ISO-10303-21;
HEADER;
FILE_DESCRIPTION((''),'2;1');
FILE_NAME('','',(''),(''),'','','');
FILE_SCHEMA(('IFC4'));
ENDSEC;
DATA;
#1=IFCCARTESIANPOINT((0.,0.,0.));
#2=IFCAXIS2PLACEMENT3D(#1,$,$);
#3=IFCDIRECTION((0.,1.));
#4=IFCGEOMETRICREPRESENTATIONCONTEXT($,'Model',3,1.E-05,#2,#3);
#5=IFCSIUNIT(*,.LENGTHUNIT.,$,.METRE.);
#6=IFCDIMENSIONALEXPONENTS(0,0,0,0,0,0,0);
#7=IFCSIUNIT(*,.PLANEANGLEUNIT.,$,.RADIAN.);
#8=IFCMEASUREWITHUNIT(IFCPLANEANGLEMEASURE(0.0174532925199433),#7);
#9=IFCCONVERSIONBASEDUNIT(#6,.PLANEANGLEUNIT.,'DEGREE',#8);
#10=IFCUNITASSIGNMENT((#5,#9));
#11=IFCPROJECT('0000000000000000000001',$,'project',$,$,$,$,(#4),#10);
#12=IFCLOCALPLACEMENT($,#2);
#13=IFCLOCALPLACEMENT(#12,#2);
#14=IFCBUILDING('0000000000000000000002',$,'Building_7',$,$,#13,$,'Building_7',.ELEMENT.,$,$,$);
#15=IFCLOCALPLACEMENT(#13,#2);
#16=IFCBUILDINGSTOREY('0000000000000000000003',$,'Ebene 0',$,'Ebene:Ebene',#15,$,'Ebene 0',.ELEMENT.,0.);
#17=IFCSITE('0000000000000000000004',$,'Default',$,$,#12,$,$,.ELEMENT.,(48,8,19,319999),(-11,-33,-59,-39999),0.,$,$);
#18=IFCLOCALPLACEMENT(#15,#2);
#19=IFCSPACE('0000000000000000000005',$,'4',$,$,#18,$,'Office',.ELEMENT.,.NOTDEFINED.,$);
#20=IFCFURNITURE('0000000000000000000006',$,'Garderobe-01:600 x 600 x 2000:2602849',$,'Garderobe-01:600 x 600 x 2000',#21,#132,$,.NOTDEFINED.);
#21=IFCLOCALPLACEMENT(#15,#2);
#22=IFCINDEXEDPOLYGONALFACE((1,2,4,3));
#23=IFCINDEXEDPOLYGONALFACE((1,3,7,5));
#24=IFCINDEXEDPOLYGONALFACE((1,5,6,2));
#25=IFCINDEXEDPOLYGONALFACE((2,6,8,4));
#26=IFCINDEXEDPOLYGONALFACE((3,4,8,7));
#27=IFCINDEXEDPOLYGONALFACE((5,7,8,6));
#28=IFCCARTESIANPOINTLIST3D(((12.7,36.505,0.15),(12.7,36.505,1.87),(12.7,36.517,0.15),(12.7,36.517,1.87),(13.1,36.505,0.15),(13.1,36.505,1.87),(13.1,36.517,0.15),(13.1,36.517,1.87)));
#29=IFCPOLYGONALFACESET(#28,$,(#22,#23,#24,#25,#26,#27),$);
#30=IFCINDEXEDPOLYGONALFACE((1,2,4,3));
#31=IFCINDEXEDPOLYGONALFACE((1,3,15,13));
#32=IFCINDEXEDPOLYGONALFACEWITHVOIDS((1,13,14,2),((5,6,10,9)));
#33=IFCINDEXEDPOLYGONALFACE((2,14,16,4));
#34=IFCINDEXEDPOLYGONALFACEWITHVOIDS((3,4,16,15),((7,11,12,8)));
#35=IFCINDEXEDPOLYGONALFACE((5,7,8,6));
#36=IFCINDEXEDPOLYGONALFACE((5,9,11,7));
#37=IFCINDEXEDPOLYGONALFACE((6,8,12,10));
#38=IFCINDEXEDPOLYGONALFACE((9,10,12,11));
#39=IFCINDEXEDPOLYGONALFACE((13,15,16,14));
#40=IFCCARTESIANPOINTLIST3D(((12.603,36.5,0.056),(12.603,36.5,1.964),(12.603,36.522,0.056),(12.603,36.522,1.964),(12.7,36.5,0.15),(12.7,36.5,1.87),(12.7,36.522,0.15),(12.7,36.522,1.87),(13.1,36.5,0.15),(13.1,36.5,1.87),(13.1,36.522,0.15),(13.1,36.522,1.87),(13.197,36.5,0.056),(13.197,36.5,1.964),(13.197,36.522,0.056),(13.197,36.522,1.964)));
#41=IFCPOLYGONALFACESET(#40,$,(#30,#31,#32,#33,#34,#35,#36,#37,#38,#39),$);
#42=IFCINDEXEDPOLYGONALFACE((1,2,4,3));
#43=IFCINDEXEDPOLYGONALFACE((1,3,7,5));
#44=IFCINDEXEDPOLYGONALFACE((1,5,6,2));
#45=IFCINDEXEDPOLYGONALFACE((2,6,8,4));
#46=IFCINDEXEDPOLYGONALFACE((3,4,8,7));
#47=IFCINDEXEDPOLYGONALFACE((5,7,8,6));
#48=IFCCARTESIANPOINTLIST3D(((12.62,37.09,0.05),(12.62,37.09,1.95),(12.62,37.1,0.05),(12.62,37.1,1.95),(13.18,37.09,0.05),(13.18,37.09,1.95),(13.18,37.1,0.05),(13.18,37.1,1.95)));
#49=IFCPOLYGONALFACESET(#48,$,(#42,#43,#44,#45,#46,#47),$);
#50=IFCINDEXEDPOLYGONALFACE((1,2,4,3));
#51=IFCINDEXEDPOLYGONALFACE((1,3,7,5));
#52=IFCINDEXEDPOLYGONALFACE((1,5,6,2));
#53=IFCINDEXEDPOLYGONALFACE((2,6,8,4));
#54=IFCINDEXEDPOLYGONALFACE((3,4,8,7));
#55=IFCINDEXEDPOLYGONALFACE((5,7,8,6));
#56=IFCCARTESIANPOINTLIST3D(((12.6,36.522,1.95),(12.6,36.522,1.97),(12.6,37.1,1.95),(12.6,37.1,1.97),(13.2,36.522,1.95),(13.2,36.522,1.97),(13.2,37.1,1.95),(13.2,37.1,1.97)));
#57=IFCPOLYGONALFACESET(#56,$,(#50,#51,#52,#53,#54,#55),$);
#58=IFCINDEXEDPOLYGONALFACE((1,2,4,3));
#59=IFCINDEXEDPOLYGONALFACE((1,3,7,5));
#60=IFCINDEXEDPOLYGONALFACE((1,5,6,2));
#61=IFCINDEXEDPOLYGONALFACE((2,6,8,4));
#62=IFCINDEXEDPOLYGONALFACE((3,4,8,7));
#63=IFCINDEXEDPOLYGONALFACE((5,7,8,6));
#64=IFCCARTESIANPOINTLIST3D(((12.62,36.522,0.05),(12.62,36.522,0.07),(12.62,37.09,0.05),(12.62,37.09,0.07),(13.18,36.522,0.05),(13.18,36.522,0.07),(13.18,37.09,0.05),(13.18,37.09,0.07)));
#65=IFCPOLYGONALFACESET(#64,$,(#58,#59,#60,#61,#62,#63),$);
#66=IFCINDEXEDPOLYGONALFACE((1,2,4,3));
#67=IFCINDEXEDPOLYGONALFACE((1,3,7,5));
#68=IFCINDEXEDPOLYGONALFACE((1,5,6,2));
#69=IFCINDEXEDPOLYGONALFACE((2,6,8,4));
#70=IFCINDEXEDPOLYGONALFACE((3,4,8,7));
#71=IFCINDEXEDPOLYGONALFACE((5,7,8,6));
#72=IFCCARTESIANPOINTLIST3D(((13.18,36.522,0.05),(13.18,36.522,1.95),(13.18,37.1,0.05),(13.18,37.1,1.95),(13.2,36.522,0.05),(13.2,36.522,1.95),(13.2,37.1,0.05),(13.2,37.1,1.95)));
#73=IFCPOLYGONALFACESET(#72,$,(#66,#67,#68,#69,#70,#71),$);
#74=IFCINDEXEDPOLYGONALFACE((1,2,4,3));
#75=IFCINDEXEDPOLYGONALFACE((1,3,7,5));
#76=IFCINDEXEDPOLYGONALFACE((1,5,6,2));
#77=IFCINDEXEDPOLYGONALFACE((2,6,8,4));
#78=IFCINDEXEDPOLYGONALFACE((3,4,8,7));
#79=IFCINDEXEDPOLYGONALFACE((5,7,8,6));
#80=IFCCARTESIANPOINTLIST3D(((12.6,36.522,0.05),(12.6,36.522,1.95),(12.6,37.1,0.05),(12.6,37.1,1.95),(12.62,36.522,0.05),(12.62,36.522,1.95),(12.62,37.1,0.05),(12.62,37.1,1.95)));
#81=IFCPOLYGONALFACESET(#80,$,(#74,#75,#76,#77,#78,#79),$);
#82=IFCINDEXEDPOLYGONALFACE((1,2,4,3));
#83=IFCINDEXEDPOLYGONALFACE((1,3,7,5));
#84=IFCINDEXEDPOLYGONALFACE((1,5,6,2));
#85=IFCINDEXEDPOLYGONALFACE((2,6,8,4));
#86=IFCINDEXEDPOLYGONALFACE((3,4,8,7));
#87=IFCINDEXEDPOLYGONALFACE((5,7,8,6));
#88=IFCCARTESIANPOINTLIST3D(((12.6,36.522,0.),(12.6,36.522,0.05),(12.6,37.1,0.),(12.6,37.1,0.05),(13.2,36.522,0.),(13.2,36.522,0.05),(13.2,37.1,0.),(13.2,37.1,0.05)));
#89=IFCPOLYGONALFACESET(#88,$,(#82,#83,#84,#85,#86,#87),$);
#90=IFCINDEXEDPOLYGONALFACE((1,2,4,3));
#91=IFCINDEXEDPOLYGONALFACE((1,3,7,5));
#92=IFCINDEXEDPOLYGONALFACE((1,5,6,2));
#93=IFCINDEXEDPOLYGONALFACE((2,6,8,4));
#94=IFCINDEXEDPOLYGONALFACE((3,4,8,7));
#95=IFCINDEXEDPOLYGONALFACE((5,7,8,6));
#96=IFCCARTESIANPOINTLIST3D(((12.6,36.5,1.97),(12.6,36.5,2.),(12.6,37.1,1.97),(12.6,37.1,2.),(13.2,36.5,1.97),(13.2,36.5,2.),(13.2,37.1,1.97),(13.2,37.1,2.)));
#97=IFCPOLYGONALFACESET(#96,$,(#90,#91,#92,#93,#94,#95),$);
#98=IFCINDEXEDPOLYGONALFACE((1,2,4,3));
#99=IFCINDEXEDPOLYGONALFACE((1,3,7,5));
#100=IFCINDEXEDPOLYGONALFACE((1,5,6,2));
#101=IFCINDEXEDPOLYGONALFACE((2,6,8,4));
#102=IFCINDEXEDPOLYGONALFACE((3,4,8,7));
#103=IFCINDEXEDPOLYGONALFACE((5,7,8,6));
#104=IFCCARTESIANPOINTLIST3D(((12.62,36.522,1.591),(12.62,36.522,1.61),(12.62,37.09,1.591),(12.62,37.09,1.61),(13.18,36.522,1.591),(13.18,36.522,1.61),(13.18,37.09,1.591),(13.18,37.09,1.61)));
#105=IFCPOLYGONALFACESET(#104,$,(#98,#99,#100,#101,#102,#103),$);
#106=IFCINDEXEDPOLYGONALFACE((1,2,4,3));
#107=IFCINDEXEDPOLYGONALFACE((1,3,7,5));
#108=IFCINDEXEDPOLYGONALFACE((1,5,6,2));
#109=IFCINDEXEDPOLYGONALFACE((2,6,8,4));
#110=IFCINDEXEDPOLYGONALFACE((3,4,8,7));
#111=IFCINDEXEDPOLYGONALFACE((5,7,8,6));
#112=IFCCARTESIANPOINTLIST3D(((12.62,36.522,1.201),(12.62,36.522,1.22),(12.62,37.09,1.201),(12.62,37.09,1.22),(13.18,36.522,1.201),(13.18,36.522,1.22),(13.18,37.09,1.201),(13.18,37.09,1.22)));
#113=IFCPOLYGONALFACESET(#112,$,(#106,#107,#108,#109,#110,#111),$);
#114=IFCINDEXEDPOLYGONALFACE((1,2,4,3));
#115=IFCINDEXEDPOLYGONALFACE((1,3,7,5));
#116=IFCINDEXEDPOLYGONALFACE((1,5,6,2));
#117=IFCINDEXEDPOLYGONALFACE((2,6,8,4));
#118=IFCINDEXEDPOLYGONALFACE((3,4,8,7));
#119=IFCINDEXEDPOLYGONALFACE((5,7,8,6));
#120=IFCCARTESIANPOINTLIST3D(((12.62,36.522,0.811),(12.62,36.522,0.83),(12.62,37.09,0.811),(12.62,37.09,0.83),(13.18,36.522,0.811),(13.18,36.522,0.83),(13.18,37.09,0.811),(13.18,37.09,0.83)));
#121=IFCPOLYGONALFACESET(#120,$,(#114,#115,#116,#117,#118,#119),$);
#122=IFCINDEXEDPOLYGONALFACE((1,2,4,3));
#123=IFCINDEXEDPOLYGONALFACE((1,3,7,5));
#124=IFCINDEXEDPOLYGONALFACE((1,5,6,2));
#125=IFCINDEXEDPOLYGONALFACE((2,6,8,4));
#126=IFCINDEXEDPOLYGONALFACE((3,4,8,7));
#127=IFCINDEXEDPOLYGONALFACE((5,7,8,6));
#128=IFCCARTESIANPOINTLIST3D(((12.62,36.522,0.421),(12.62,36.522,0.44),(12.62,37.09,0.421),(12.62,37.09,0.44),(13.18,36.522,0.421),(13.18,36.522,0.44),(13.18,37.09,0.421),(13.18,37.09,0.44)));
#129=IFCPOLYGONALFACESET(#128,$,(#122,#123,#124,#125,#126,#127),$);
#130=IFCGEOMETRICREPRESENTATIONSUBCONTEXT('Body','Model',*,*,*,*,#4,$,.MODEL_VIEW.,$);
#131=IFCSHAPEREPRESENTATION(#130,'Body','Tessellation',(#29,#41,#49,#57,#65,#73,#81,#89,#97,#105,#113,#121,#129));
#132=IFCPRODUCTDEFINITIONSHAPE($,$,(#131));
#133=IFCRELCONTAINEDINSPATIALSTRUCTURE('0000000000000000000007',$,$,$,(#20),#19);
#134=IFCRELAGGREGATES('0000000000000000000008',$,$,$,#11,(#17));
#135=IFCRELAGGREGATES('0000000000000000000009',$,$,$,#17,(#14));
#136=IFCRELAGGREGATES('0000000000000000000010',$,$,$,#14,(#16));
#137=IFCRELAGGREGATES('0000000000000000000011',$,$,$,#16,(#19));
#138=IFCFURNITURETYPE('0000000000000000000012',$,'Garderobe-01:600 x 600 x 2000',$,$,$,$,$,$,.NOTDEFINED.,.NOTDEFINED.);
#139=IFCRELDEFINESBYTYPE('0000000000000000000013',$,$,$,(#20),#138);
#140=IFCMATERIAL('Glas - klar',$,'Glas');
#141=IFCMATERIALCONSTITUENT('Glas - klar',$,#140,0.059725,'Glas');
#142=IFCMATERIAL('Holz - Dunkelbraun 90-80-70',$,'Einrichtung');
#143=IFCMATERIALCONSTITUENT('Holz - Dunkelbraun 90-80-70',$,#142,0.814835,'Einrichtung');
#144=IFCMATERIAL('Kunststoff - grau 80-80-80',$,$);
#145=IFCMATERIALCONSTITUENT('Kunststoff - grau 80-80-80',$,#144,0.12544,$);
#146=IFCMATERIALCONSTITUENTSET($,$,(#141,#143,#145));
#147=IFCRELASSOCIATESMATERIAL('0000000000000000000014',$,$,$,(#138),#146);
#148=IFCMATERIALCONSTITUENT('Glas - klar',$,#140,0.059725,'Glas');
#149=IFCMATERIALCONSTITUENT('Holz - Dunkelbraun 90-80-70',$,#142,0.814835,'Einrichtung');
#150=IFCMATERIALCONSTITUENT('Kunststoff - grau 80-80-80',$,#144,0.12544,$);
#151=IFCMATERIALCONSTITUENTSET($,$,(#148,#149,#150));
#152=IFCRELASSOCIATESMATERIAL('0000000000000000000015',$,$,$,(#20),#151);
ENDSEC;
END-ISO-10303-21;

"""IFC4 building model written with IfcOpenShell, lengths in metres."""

from ifc_helpers import new_model, entity, si_unit, converted_unit, direction, frame, origin, place, context, subcontext, project, spatial, indexed_curve, outline, extrude, source, transform, mapped, material, constituent, constituent_set, type_object, type_shapes, element, save


model = new_model("IFC4")

# Units and contexts
model_context = context("Model", 3, precision=1e-05, world=origin(), true_north=direction((0.0, 1.0)))
body_context = subcontext(model_context, "Body", "Model", "MODEL_VIEW")
ifc_project = project(units=[si_unit("LENGTHUNIT", "METRE"), converted_unit("PLANEANGLEUNIT", "DEGREE", entity("IfcPlaneAngleMeasure", 0.0174532925199433), si_unit("PLANEANGLEUNIT", "RADIAN"), dimensions=[0, 0, 0, 0, 0, 0, 0])], contexts=[model_context])

# Site, building, storey
site_placement = place(None, origin())
site = spatial("IfcSite", under=ifc_project, at=site_placement, Name="Default", CompositionType="ELEMENT", RefLatitude=(48, 8, 19, 319999), RefLongitude=(-11, -33, -59, -39999), RefElevation=0.0)
building_placement = place(site_placement, origin())
building = spatial("IfcBuilding", under=site, at=building_placement, Name="Building_7", LongName="Building_7", CompositionType="ELEMENT")
storey_placement = place(building_placement, origin())
storey = spatial("IfcBuildingStorey", under=building, at=storey_placement, Name="Ebene 0", ObjectType="Ebene:Ebene", LongName="Ebene 0", CompositionType="ELEMENT", Elevation=0.0)

# Shared definitions
ifc_material_1 = material(Name="Glas - klar", Category="Glas")
ifc_material_2 = material(Name="Holz - Dunkelbraun 90-80-70", Category="Einrichtung")
ifc_material_3 = material(Name="Kunststoff - grau 80-80-80")
ifc_constituent_1 = constituent(ifc_material_1, Name="Glas - klar", Category="Glas", fraction=0.059725)
ifc_constituent_2 = constituent(ifc_material_2, Name="Holz - Dunkelbraun 90-80-70", Category="Einrichtung", fraction=0.814835)
ifc_constituent_3 = constituent(ifc_material_3, Name="Kunststoff - grau 80-80-80", fraction=0.12544)
ifc_constituent_set_1 = constituent_set(constituents=[ifc_constituent_1, ifc_constituent_2, ifc_constituent_3])
furniture_type_1 = type_object("IfcFurnitureType", Name="Garderobe-01:600 x 600 x 2000", AssemblyPlace="NOTDEFINED", PredefinedType="NOTDEFINED", material=ifc_constituent_set_1)
shared_shape_1 = source(origin(), body_context, "Body", "SweptSolid", [
    extrude(outline(indexed_curve([(-0.006, -0.2), (0.006, -0.2), (0.006, 0.2), (-0.006, 0.2), (-0.006, -0.2)], self_intersect=False)), frame((0.0, -0.289, 0.15), z_axis=(0.0, 0.0, 1.0), x_axis=(0.0, 1.0, 0.0)), (0.0, 0.0, 1.0), 1.72),
    extrude(outline(indexed_curve([(-0.954, -0.297), (0.954, -0.297), (0.954, 0.297), (-0.954, 0.297), (-0.954, -0.297)], self_intersect=False), holes=[indexed_curve([(-0.86, 0.2), (0.86, 0.2), (0.86, -0.2), (-0.86, -0.2), (-0.86, 0.2)], self_intersect=False)]), frame((0.0, -0.3, 1.01), z_axis=(0.0, 1.0, 0.0), x_axis=(0.0, 0.0, -1.0)), (0.0, 0.0, 1.0), 0.022),
    extrude(outline(indexed_curve([(-0.28, -0.005), (0.28, -0.005), (0.28, 0.005), (-0.28, 0.005), (-0.28, -0.005)], self_intersect=False)), frame((0.0, 0.295, 0.05), z_axis=(0.0, 0.0, 1.0), x_axis=(-1.0, 0.0, 0.0)), (0.0, 0.0, 1.0), 1.9),
    extrude(outline(indexed_curve([(-0.3, -0.289), (0.3, -0.289), (0.3, 0.289), (-0.3, 0.289), (-0.3, -0.289)], self_intersect=False)), frame((0.0, 0.011, 1.95), z_axis=(0.0, 0.0, 1.0), x_axis=(-1.0, 0.0, 0.0)), (0.0, 0.0, 1.0), 0.02),
    extrude(outline(indexed_curve([(-0.28, -0.284), (0.28, -0.284), (0.28, 0.284), (-0.28, 0.284), (-0.28, -0.284)], self_intersect=False)), frame((0.0, 0.006, 0.05), z_axis=(0.0, 0.0, 1.0), x_axis=(-1.0, 0.0, 0.0)), (0.0, 0.0, 1.0), 0.02),
    extrude(outline(indexed_curve([(-0.01, -0.289), (0.01, -0.289), (0.01, 0.289), (-0.01, 0.289), (-0.01, -0.289)], self_intersect=False)), frame((0.29, 0.011, 0.05), z_axis=(0.0, 0.0, 1.0), x_axis=(-1.0, 0.0, 0.0)), (0.0, 0.0, 1.0), 1.9),
    extrude(outline(indexed_curve([(-0.01, -0.289), (0.01, -0.289), (0.01, 0.289), (-0.01, 0.289), (-0.01, -0.289)], self_intersect=False)), frame((-0.29, 0.011, 0.05), z_axis=(0.0, 0.0, 1.0), x_axis=(-1.0, 0.0, 0.0)), (0.0, 0.0, 1.0), 1.9),
    extrude(outline(indexed_curve([(-0.3, -0.289), (0.3, -0.289), (0.3, 0.289), (-0.3, 0.289), (-0.3, -0.289)], self_intersect=False)), frame((0.0, 0.011, 0.0), z_axis=(0.0, 0.0, 1.0), x_axis=(-1.0, 0.0, 0.0)), (0.0, 0.0, 1.0), 0.05),
    extrude(outline(indexed_curve([(-0.3, -0.3), (0.3, -0.3), (0.3, 0.3), (-0.3, 0.3), (-0.3, -0.3)], self_intersect=False)), frame((0.0, 0.0, 1.97), z_axis=(0.0, 0.0, 1.0), x_axis=(-1.0, 0.0, 0.0)), (0.0, 0.0, 1.0), 0.03),
    extrude(outline(indexed_curve([(-0.28, -0.284), (0.28, -0.284), (0.28, 0.284), (-0.28, 0.284), (-0.28, -0.284)], self_intersect=False)), frame((0.0, 0.006, 1.591), z_axis=(0.0, 0.0, 1.0), x_axis=(-1.0, 0.0, 0.0)), (0.0, 0.0, 1.0), 0.019),
    extrude(outline(indexed_curve([(-0.28, -0.284), (0.28, -0.284), (0.28, 0.284), (-0.28, 0.284), (-0.28, -0.284)], self_intersect=False)), frame((0.0, 0.006, 1.201), z_axis=(0.0, 0.0, 1.0), x_axis=(-1.0, 0.0, 0.0)), (0.0, 0.0, 1.0), 0.019),
    extrude(outline(indexed_curve([(-0.28, -0.284), (0.28, -0.284), (0.28, 0.284), (-0.28, 0.284), (-0.28, -0.284)], self_intersect=False)), frame((0.0, 0.006, 0.811), z_axis=(0.0, 0.0, 1.0), x_axis=(-1.0, 0.0, 0.0)), (0.0, 0.0, 1.0), 0.019),
    extrude(outline(indexed_curve([(-0.28, -0.284), (0.28, -0.284), (0.28, 0.284), (-0.28, 0.284), (-0.28, -0.284)], self_intersect=False)), frame((0.0, 0.006, 0.421), z_axis=(0.0, 0.0, 1.0), x_axis=(-1.0, 0.0, 0.0)), (0.0, 0.0, 1.0), 0.019),
])
type_shapes(furniture_type_1, [shared_shape_1])

# Shared definitions
space_1_placement = place(storey_placement, origin())
space_1 = spatial("IfcSpace", under=storey, at=space_1_placement, Name="4", LongName="Office", CompositionType="ELEMENT", PredefinedType="NOTDEFINED")

# Furniture
ifc_constituent_4 = constituent(ifc_material_1, Name="Glas - klar", Category="Glas", fraction=0.059725)
ifc_constituent_5 = constituent(ifc_material_2, Name="Holz - Dunkelbraun 90-80-70", Category="Einrichtung", fraction=0.814835)
ifc_constituent_6 = constituent(ifc_material_3, Name="Kunststoff - grau 80-80-80", fraction=0.12544)
ifc_constituent_set_2 = constituent_set(constituents=[ifc_constituent_4, ifc_constituent_5, ifc_constituent_6])
furniture_1_placement = place(space_1_placement, frame((12.9, 36.8, 0.0)))
element("IfcFurniture", 1, at=furniture_1_placement, inside=space_1, type_object=furniture_type_1, material=ifc_constituent_set_2, Name="Garderobe-01:600 x 600 x 2000:2602849", ObjectType="Garderobe-01:600 x 600 x 2000", PredefinedType="NOTDEFINED", context=body_context, shape_type="MappedRepresentation", body=[
    mapped(shared_shape_1, transform((0.0, 0.0, 0.0), scale=1.0)),
])

save(model, "model.ifc")
